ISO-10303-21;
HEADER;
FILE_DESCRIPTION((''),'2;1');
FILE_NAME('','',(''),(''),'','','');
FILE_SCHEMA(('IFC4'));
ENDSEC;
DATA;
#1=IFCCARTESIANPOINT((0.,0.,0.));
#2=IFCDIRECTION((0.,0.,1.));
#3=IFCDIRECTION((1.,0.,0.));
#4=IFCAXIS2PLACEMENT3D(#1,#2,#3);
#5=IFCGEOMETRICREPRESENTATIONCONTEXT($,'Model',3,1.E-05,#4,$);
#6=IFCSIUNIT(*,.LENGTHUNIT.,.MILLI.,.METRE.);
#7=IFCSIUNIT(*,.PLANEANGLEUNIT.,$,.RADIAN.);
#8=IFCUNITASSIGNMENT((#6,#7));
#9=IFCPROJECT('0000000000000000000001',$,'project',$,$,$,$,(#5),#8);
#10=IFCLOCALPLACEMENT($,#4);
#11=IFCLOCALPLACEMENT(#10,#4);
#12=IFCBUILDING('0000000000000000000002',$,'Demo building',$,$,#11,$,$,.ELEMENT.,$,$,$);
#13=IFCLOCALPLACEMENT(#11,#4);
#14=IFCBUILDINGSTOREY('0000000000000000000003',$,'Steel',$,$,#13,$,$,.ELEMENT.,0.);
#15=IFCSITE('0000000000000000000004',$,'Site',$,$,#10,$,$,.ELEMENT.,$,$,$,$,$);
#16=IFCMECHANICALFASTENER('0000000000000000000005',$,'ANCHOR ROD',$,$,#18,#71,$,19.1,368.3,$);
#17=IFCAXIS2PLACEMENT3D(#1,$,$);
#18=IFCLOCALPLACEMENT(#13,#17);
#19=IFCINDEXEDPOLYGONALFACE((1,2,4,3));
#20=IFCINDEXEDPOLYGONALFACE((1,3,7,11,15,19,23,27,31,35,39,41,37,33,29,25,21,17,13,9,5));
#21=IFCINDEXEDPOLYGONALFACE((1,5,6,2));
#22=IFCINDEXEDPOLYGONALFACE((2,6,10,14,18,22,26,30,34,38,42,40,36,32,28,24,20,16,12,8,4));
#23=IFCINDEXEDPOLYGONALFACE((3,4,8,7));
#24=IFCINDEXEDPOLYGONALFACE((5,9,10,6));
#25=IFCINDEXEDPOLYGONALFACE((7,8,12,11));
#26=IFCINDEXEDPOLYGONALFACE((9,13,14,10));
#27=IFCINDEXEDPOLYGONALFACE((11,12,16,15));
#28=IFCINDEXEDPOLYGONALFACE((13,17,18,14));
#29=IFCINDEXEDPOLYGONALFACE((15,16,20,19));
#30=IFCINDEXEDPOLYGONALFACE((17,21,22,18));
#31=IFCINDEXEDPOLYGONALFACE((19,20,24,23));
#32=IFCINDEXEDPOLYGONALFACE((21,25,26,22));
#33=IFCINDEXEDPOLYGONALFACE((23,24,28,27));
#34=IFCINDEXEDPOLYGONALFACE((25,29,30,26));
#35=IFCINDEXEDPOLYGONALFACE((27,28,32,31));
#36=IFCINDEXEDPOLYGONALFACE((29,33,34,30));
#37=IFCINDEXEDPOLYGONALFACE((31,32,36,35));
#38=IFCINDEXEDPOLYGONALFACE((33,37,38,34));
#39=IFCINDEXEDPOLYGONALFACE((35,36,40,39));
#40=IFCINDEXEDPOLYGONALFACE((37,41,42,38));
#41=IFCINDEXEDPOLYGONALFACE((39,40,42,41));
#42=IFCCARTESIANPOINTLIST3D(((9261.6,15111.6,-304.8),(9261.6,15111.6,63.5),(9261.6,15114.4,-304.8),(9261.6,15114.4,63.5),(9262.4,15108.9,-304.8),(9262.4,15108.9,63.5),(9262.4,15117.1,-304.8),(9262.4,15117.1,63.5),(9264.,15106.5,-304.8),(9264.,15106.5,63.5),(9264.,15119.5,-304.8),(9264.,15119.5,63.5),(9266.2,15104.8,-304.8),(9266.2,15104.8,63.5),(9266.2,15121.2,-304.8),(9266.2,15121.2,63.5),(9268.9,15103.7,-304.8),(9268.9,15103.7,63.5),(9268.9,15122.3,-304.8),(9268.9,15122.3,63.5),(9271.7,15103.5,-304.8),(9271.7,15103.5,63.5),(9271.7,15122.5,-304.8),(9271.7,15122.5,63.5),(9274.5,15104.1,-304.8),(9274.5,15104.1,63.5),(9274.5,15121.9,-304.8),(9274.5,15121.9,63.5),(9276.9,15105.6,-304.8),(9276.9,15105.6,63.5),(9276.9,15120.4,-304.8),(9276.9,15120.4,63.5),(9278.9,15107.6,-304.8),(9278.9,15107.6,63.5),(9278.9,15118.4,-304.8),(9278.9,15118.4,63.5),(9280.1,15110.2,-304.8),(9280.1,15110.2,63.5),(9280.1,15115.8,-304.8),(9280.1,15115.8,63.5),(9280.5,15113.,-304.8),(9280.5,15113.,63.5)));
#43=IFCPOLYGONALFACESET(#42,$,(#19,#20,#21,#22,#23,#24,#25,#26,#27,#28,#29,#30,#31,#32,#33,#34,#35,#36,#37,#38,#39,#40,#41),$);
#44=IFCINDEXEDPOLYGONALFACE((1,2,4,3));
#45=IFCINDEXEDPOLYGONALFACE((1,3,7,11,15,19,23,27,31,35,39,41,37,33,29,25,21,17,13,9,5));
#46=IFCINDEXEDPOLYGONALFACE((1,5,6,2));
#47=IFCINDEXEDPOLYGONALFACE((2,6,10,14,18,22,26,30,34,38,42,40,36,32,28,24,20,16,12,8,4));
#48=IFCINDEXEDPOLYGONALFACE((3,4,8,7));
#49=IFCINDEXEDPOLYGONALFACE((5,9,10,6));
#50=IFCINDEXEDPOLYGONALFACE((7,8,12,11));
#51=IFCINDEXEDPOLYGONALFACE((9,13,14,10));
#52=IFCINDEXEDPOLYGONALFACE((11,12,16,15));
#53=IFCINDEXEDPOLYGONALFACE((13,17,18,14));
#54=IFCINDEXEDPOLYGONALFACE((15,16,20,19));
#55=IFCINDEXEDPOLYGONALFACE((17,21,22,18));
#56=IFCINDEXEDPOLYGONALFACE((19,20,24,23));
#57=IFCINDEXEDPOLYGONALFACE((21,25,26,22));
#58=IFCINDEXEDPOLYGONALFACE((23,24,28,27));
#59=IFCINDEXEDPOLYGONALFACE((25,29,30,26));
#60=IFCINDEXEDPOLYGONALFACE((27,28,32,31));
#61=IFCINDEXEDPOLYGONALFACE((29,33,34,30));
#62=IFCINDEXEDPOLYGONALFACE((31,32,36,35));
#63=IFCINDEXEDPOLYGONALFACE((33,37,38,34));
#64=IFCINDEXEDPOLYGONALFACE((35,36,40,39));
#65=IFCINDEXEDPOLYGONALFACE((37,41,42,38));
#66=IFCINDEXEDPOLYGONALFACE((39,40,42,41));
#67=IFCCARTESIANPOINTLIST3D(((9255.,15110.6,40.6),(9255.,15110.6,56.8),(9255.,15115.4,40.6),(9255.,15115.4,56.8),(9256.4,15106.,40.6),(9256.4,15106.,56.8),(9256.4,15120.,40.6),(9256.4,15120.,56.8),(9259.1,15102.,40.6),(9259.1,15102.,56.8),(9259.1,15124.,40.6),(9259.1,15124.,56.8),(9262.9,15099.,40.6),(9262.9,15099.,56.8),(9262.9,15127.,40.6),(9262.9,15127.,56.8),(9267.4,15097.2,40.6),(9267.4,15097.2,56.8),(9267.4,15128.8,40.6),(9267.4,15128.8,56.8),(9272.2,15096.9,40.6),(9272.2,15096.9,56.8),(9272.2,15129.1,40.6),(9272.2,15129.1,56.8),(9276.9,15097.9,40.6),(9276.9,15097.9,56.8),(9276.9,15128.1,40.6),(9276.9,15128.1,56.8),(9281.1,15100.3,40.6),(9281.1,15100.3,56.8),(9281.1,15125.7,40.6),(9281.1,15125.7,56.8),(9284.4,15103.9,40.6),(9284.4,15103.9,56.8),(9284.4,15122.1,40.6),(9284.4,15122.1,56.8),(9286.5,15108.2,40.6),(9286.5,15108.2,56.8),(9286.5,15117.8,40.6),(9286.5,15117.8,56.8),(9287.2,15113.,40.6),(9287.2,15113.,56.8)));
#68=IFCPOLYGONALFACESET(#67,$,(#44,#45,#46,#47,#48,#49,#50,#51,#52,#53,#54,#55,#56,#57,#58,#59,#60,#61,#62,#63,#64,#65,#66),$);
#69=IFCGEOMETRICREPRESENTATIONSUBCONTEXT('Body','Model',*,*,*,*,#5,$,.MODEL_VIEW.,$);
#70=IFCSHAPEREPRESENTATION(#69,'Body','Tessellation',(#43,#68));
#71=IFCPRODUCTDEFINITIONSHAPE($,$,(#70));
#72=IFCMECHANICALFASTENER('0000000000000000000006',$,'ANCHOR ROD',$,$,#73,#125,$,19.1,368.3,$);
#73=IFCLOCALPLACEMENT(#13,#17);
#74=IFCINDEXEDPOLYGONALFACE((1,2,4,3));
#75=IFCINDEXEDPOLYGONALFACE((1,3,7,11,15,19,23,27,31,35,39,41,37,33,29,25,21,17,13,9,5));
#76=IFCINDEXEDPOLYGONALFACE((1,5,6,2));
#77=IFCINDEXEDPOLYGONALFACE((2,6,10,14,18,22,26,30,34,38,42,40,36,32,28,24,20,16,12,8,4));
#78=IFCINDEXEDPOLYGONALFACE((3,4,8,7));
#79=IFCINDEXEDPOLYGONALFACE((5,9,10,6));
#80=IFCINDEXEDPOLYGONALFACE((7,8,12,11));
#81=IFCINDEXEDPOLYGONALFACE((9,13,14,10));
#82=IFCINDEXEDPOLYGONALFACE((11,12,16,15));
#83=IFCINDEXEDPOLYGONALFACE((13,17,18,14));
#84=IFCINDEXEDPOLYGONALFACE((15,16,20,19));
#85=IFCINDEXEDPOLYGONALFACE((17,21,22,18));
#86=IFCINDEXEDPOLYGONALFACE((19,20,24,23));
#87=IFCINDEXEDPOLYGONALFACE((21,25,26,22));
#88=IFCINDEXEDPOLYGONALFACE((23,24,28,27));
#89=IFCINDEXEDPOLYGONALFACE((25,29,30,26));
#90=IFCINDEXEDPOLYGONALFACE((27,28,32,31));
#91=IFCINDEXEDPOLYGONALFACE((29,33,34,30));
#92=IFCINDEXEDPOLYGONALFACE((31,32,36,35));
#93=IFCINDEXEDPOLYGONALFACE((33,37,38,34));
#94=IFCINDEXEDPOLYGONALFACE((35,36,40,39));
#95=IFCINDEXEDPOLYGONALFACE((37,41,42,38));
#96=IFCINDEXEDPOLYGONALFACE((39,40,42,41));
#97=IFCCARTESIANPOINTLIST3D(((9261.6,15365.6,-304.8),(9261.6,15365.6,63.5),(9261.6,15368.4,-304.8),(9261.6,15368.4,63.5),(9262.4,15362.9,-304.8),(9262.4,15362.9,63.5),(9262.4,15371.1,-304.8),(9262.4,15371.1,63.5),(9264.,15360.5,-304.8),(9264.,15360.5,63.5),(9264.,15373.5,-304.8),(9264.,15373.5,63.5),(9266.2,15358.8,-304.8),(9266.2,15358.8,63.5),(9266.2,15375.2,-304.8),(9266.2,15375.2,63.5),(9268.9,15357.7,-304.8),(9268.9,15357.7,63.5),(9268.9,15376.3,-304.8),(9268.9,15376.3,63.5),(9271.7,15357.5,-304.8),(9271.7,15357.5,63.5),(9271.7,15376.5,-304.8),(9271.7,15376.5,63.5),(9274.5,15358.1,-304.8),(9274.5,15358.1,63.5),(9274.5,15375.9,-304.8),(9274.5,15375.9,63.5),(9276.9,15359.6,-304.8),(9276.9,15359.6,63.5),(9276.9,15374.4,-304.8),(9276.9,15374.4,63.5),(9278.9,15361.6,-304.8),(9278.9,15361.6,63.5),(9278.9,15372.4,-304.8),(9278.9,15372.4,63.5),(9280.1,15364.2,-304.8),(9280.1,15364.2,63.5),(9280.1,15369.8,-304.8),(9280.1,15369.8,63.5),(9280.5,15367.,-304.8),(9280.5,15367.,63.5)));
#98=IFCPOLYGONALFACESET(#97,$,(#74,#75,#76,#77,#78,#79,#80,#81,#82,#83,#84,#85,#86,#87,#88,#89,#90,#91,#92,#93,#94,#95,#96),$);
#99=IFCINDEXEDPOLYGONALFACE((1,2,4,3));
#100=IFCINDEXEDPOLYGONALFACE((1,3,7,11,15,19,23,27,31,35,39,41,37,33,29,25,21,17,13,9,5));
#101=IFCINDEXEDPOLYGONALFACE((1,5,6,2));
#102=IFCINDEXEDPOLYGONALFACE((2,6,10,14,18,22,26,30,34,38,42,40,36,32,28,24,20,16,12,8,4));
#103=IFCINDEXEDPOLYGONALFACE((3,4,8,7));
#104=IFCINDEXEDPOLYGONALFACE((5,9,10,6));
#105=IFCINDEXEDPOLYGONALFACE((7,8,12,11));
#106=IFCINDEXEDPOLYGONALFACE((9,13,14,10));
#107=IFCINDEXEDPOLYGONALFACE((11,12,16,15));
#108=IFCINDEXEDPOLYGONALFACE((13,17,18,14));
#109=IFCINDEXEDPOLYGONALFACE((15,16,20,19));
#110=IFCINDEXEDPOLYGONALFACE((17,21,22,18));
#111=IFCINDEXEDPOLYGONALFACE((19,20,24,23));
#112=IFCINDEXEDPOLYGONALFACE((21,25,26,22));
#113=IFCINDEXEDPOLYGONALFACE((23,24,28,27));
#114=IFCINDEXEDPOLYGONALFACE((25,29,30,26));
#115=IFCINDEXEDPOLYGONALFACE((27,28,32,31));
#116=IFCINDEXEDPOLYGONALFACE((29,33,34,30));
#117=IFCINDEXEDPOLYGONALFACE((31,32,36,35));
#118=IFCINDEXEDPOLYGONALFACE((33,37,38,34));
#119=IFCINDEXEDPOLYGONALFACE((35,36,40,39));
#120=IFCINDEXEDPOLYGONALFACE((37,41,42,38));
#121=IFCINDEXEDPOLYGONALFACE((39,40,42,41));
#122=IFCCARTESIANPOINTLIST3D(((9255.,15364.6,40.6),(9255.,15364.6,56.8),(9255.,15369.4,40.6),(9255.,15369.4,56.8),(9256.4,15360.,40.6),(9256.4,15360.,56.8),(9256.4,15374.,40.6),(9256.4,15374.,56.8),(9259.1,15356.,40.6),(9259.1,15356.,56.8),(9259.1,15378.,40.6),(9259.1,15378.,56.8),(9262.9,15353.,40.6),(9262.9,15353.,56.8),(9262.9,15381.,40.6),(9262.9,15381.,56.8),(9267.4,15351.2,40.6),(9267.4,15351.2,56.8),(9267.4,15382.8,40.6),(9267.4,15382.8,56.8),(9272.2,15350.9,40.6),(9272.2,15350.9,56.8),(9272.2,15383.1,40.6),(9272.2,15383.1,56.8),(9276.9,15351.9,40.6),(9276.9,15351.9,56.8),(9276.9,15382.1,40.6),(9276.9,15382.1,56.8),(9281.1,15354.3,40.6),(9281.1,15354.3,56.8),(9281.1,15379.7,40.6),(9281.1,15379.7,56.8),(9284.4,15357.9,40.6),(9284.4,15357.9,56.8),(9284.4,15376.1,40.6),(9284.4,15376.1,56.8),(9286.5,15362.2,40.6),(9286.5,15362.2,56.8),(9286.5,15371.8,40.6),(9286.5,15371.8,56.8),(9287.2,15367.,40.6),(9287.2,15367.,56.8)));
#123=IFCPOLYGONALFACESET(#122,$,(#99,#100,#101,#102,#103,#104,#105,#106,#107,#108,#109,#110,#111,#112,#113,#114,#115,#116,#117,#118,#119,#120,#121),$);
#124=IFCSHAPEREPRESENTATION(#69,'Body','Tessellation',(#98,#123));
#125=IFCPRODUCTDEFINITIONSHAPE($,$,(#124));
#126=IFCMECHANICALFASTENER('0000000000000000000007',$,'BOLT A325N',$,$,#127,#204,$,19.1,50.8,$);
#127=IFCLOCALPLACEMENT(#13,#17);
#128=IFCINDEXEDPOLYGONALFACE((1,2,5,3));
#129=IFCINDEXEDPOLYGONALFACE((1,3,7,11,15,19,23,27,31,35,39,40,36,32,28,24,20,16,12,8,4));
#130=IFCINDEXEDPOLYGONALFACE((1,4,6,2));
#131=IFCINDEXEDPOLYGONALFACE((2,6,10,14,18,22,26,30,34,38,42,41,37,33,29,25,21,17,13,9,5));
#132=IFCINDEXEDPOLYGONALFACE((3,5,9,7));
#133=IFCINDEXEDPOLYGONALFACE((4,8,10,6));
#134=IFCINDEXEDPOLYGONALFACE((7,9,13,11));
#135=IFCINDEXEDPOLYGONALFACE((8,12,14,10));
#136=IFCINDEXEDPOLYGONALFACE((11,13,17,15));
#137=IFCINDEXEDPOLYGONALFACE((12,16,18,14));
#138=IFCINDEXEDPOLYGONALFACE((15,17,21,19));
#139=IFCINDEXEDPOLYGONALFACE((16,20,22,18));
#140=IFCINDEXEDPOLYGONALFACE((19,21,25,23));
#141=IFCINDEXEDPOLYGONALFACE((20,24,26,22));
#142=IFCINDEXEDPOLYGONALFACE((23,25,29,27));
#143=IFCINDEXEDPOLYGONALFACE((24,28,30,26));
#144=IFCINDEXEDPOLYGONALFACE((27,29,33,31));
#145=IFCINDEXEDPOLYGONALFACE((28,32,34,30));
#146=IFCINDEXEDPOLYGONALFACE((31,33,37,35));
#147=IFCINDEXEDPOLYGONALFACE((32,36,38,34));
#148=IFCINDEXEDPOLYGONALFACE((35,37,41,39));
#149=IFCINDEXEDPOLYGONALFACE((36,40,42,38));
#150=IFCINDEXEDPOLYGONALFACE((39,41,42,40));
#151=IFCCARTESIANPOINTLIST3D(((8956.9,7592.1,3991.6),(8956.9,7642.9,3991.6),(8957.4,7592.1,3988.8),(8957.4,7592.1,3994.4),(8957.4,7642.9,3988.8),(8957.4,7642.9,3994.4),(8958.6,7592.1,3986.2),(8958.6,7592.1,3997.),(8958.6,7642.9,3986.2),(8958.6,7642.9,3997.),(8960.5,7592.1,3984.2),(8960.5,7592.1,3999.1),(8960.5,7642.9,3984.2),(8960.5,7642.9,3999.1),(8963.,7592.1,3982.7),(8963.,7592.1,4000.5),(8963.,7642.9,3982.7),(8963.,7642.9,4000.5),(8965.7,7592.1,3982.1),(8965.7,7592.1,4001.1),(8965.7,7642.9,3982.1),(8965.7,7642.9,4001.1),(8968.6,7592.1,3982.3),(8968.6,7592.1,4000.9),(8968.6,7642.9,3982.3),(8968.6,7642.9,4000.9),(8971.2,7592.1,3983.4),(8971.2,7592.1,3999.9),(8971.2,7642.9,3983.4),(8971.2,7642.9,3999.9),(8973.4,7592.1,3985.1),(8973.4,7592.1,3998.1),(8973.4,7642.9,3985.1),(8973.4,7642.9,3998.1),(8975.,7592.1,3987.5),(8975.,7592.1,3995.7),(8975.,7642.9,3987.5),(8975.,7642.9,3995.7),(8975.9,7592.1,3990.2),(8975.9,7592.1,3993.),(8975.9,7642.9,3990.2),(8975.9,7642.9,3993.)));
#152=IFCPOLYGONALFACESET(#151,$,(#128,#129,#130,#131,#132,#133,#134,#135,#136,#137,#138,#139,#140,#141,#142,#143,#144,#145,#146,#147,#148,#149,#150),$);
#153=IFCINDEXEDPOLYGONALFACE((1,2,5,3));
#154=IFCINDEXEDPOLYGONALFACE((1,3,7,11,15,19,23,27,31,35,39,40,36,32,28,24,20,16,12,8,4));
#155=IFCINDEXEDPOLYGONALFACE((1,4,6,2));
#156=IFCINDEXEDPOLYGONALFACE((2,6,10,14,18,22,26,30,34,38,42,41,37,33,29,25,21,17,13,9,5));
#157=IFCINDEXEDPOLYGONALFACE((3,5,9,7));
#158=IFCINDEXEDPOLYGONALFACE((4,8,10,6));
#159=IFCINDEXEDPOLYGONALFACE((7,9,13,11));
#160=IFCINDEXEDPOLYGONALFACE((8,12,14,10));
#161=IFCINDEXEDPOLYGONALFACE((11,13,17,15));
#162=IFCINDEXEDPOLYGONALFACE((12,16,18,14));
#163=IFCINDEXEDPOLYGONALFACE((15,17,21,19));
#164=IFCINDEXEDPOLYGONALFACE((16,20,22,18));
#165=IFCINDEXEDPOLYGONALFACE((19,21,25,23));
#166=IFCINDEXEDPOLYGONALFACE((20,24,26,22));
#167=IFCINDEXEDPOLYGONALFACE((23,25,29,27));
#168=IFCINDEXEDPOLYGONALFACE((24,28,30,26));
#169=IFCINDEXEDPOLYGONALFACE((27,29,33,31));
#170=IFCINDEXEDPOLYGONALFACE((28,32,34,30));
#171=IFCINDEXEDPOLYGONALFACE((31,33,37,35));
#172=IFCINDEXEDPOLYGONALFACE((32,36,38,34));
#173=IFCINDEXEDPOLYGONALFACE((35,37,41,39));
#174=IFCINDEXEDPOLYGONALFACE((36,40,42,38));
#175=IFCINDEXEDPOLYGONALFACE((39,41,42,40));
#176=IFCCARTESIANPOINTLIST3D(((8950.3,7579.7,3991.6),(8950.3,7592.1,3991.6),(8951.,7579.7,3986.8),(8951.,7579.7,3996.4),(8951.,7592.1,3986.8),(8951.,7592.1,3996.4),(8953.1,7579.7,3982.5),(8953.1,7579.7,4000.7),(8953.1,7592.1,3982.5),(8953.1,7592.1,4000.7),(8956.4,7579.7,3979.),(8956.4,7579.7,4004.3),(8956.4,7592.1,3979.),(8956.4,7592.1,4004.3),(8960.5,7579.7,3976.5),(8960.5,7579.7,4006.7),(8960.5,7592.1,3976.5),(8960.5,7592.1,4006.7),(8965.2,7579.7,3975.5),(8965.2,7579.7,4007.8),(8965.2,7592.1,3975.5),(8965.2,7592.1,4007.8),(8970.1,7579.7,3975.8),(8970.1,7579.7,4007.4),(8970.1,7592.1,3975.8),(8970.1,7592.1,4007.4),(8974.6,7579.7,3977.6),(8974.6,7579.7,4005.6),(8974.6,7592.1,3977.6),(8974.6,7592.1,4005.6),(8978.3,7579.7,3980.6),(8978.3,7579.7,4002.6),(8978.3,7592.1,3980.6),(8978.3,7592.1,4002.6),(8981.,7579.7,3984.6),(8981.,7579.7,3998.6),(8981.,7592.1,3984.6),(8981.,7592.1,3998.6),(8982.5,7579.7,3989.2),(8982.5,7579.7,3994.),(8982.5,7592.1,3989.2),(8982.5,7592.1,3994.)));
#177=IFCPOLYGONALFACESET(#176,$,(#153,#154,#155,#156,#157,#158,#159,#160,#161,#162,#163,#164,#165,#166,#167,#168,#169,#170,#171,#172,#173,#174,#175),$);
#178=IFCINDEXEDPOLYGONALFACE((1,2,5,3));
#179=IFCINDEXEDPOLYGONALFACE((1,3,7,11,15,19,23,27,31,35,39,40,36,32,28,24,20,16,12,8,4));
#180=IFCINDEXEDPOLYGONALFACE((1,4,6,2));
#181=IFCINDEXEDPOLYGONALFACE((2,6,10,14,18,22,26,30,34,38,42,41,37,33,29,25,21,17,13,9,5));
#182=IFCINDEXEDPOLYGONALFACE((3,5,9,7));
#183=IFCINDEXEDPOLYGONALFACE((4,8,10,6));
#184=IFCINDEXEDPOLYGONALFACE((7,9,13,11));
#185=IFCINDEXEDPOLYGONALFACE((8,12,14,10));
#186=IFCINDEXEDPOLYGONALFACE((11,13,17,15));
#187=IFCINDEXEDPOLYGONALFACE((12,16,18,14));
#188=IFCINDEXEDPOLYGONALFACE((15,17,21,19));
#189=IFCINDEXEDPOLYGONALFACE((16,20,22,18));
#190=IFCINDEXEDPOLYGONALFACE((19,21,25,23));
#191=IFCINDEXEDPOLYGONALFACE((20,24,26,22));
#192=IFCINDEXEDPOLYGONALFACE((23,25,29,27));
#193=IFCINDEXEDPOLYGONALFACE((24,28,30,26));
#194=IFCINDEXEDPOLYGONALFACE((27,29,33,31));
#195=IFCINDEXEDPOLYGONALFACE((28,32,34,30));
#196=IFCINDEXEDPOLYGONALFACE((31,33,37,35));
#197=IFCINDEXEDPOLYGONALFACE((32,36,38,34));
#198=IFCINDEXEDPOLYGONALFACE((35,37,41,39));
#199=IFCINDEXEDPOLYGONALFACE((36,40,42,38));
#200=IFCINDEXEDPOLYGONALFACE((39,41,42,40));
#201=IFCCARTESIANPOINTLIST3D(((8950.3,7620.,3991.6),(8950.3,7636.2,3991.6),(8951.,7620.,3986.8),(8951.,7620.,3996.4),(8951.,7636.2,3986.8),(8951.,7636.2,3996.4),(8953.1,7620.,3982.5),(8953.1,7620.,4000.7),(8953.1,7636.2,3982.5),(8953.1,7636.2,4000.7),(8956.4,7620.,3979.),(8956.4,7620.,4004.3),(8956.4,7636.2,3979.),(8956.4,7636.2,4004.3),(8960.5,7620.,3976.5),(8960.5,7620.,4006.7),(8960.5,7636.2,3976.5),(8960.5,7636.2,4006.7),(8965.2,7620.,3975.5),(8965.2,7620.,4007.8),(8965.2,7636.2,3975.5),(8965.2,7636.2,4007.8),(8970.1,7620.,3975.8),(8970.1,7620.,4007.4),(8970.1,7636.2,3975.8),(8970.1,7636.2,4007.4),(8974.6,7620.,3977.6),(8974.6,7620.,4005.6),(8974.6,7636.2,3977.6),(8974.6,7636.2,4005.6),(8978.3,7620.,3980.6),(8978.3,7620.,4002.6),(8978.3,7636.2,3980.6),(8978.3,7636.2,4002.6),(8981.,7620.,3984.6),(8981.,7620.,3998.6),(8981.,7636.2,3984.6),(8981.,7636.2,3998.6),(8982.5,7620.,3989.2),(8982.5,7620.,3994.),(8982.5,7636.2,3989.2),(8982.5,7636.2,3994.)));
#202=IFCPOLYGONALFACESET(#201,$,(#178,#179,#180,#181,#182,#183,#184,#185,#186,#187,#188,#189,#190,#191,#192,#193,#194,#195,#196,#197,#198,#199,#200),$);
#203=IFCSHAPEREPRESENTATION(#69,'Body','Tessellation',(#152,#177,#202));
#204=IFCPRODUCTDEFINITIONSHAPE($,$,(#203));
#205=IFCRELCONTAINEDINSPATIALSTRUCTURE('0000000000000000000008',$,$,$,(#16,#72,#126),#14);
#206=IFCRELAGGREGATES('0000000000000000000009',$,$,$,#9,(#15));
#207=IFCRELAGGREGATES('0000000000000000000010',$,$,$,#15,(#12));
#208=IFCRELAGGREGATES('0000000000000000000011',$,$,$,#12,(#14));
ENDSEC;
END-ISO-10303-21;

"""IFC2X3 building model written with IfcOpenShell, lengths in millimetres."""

from ifc_helpers import new_model, si_unit, frame, origin, origin_with_axes, origin_2d, place, context, subcontext, project, spatial, circle, extrude, element, save


model = new_model("IFC2X3")

# Units and contexts
model_context = context("Model", 3, precision=1e-05, world=origin_with_axes())
body_context = subcontext(model_context, "Body", "Model", "MODEL_VIEW")
ifc_project = project(units=[si_unit("LENGTHUNIT", "METRE", prefix="MILLI"), si_unit("PLANEANGLEUNIT", "RADIAN")], contexts=[model_context])

# Site, building, storey
site_placement = place(None, origin_with_axes())
site = spatial("IfcSite", under=ifc_project, at=site_placement, Name="Site", CompositionType="ELEMENT")
building_placement = place(site_placement, origin_with_axes())
building = spatial("IfcBuilding", under=site, at=building_placement, Name="Demo building", CompositionType="ELEMENT")
placement = place(building_placement, origin_with_axes())
storey = spatial("IfcBuildingStorey", under=building, at=placement, Name="Steel", CompositionType="ELEMENT", Elevation=0.0)

# Mechanical fasteners
for number, where, z_axis, x_axis, name in (
    (1, (9271.0, 15113.0, -304.8), (0.0, 0.0, 1.0), (1.0, 0.0, 0.0), "ANCHOR ROD"),
    (2, (9271.0, 15367.0, -304.8), (0.0, 0.0, 1.0), (1.0, 0.0, 0.0), "ANCHOR ROD"),
):
    element("IfcMechanicalFastener", number, at=place(placement, frame(where, z_axis=z_axis, x_axis=x_axis)), inside=storey, Name=name, NominalDiameter=19.1, NominalLength=368.3, context=body_context, shape_type="SweptSolid", body=[
        extrude(circle(Radius=9.5, at=origin_2d()), origin(), (0.0, 0.0, 1.0), 368.3),
        extrude(circle(Radius=16.2, at=origin_2d()), frame((0.0, 0.0, 345.4)), (0.0, 0.0, 1.0), 16.2),
    ])
for number, where, z_axis, x_axis, name in (
    (3, (8966.5, 7592.1, 3991.6), (0.0, 1.0, 0.0), (-1.0, 0.0, 0.0), "BOLT A325N"),
):
    element("IfcMechanicalFastener", number, at=place(placement, frame(where, z_axis=z_axis, x_axis=x_axis)), inside=storey, Name=name, NominalDiameter=19.1, NominalLength=50.8, context=body_context, shape_type="SweptSolid", body=[
        extrude(circle(Radius=9.5, at=origin_2d()), origin(), (0.0, 0.0, 1.0), 50.8),
        extrude(circle(Radius=16.2, at=origin_2d()), frame((0.0, 0.0, -12.4)), (0.0, 0.0, 1.0), 12.4),
        extrude(circle(Radius=16.2, at=origin_2d()), frame((0.0, 0.0, 27.9)), (0.0, 0.0, 1.0), 16.2),
    ])

save(model, "model.ifc")
